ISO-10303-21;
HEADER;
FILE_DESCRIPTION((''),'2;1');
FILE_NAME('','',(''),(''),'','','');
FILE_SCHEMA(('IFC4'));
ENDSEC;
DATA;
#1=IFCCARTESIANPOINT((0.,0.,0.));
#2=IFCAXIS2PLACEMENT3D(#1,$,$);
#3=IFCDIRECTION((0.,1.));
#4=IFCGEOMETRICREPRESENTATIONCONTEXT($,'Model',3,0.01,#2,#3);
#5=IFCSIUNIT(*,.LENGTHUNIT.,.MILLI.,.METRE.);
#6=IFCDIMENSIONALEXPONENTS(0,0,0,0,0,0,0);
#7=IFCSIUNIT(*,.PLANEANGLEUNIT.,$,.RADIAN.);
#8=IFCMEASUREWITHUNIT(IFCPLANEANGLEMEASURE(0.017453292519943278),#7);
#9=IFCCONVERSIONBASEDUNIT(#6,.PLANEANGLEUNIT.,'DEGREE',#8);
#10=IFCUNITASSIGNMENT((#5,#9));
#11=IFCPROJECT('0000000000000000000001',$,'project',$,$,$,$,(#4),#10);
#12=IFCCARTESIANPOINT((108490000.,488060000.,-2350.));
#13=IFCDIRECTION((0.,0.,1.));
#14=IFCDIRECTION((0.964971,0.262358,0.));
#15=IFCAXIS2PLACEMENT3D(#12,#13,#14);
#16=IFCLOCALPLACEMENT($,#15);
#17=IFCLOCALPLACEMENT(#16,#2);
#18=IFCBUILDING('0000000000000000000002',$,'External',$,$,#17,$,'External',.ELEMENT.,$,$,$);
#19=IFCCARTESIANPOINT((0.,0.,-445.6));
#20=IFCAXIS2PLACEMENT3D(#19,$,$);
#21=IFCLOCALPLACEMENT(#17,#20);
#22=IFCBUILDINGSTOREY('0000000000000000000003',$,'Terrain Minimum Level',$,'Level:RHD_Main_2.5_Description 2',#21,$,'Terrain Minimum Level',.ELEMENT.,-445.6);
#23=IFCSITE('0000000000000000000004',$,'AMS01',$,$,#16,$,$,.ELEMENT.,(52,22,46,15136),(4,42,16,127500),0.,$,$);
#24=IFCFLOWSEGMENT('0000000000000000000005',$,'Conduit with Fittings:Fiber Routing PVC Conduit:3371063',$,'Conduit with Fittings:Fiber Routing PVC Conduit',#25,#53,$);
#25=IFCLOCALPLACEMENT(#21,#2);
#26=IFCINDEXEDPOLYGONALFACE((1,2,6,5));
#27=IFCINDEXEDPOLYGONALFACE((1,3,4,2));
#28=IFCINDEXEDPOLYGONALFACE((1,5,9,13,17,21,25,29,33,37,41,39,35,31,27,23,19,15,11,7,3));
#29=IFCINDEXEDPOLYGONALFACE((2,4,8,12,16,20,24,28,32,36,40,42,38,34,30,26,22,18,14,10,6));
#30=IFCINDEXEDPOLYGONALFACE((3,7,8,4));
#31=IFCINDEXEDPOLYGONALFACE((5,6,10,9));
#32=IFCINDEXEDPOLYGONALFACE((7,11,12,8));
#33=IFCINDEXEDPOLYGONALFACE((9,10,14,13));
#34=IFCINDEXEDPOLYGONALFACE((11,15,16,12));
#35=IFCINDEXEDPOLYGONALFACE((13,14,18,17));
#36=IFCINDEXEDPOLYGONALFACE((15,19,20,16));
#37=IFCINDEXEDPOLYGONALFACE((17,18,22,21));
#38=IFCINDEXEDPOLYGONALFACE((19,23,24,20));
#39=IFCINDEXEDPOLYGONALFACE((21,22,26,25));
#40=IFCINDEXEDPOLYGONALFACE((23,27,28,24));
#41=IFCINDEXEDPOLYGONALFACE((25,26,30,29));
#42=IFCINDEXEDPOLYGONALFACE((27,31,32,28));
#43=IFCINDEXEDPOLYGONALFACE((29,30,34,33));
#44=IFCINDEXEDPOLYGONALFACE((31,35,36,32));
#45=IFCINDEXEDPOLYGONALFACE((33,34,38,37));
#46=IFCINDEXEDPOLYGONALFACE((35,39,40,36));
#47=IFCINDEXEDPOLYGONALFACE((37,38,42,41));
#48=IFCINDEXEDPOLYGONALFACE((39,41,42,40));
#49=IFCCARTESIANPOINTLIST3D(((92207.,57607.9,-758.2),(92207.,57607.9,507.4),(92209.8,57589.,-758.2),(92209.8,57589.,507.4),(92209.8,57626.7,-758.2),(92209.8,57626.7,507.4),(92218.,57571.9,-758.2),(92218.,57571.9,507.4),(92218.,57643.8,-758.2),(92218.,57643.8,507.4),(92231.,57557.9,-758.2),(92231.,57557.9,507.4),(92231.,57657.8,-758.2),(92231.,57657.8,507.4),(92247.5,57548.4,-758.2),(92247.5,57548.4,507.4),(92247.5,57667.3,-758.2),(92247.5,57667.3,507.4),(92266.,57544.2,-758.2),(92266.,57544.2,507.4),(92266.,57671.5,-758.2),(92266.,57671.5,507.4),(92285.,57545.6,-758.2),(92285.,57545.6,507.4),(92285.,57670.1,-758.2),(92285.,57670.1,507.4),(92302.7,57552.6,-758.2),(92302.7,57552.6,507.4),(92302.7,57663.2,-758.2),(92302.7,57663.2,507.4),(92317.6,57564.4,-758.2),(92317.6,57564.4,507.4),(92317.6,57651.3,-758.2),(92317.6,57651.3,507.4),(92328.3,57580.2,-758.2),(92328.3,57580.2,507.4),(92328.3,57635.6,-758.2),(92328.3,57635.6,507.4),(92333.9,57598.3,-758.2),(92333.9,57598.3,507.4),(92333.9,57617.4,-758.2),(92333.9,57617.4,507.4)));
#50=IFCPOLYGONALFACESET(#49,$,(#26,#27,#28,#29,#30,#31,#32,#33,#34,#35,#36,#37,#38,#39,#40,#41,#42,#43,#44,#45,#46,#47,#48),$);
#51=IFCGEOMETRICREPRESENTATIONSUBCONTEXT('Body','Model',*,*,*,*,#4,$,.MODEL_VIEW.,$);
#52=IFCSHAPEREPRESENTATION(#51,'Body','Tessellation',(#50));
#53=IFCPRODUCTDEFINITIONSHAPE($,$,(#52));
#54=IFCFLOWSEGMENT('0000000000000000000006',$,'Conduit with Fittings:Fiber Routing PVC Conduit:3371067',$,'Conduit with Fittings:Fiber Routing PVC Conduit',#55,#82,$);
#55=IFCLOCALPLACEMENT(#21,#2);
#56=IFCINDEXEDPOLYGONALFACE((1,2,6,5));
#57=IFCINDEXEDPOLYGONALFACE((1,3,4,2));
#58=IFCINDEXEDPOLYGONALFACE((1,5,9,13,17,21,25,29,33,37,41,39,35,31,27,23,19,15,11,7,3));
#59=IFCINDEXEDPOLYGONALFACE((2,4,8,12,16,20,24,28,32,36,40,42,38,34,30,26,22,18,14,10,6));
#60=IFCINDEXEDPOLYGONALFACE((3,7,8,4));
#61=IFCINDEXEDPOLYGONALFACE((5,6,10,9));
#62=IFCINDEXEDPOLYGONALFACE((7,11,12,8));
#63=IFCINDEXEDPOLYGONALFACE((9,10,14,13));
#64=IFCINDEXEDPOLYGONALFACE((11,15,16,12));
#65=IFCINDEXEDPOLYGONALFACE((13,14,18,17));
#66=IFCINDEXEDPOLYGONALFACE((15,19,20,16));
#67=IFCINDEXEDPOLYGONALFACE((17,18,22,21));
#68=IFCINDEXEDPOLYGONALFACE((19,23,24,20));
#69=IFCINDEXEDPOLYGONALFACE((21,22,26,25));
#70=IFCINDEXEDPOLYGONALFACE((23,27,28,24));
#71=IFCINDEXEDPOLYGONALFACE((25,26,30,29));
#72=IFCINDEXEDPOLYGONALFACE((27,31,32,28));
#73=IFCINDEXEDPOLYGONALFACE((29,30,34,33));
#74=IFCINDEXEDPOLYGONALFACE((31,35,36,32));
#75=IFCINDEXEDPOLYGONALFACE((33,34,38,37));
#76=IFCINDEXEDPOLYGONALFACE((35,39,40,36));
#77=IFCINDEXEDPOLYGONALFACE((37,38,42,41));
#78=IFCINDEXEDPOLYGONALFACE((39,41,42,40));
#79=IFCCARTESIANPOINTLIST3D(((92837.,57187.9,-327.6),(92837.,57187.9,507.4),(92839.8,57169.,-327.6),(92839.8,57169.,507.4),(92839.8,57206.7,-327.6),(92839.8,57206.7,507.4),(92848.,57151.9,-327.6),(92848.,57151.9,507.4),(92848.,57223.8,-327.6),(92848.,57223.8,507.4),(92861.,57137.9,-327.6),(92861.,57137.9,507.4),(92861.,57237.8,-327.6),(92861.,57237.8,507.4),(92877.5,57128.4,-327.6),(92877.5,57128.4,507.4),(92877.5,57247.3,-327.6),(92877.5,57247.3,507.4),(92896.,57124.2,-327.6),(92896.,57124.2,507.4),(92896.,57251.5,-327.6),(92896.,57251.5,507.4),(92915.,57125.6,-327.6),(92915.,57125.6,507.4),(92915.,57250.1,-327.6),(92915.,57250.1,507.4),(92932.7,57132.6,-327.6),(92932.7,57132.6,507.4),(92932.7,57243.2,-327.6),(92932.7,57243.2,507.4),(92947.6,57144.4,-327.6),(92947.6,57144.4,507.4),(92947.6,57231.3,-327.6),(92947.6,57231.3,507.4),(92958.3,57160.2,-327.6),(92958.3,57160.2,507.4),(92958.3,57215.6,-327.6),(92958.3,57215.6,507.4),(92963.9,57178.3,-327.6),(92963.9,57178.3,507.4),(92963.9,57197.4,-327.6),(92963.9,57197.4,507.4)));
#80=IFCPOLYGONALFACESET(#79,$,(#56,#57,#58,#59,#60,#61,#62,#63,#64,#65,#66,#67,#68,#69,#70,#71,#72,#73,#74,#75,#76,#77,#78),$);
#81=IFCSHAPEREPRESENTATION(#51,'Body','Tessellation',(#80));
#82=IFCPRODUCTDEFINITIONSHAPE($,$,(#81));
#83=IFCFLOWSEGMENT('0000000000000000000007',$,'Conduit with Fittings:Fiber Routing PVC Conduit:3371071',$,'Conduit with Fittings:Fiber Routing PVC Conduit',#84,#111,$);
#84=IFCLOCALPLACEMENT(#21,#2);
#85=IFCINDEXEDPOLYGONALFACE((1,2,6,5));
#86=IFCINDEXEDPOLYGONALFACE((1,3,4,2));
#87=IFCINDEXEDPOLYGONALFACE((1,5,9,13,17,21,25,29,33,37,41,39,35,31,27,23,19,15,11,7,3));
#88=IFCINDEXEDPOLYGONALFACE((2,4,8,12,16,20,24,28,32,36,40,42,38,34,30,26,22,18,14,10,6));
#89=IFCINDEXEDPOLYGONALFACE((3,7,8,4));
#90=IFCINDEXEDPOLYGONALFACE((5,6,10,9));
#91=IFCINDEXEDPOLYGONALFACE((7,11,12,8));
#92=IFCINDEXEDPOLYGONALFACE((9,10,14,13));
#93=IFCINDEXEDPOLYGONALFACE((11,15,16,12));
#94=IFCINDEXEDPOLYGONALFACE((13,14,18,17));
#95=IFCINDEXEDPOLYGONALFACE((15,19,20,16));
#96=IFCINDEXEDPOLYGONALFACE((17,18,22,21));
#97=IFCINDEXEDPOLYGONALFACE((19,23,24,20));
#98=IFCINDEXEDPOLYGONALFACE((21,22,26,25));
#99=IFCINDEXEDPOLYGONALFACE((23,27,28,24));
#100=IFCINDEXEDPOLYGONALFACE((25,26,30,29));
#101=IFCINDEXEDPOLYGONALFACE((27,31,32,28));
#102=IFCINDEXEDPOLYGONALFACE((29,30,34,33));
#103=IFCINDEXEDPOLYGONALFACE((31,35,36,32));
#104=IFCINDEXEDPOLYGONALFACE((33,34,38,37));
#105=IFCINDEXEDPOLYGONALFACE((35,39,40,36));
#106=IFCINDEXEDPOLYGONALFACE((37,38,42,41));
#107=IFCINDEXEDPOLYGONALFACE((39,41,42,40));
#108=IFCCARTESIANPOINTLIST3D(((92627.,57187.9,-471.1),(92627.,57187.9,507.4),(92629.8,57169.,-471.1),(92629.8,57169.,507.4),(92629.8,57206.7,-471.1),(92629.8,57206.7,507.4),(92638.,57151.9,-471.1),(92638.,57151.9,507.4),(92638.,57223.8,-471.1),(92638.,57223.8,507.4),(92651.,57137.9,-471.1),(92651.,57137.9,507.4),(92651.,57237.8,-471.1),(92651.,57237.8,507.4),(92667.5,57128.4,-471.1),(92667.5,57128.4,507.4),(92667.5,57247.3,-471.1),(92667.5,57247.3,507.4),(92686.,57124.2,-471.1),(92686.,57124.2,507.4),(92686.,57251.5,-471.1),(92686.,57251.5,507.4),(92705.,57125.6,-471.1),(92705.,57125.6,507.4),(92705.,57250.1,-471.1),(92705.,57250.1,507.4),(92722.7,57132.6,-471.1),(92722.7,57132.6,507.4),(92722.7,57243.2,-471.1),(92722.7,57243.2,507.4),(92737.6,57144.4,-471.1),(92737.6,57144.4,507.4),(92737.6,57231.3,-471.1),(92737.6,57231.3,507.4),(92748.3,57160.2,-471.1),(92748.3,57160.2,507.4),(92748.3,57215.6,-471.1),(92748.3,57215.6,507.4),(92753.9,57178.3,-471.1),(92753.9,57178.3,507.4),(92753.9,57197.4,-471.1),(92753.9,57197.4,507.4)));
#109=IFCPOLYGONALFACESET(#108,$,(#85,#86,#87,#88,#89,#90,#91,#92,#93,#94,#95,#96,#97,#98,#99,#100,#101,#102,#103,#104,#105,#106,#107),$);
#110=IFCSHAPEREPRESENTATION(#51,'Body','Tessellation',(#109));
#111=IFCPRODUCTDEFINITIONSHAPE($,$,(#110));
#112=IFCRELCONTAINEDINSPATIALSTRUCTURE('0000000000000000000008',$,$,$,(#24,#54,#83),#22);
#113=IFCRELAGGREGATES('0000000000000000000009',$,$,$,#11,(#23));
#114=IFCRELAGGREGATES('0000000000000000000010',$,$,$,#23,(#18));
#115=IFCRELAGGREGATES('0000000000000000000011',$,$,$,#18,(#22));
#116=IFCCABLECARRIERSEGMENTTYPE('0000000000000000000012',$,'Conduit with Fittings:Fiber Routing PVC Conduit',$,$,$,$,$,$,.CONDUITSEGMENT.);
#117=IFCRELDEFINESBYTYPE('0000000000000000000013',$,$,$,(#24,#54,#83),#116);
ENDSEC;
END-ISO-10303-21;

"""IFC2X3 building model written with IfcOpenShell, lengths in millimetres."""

from ifc_helpers import new_model, entity, si_unit, converted_unit, direction, frame, frame_2d, origin, origin_2d_with_axis, place, context, subcontext, project, spatial, circle, extrude, type_object, element, save


model = new_model("IFC2X3")

# Units and contexts
model_context = context("Model", 3, precision=0.01, world=origin(), true_north=direction((0.0, 1.0)))
body_context = subcontext(model_context, "Body", "Model", "MODEL_VIEW")
ifc_project = project(units=[si_unit("LENGTHUNIT", "METRE", prefix="MILLI"), converted_unit("PLANEANGLEUNIT", "DEGREE", entity("IfcPlaneAngleMeasure", 0.017453292519943278), si_unit("PLANEANGLEUNIT", "RADIAN"), dimensions=[0, 0, 0, 0, 0, 0, 0])], contexts=[model_context])

# Site, building, storey
site_placement = place(None, frame((108490000.0, 488060000.0, -2350.0), z_axis=(0.0, 0.0, 1.0), x_axis=(0.964971, 0.262358, 0.0)))
site = spatial("IfcSite", under=ifc_project, at=site_placement, Name="AMS01", CompositionType="ELEMENT", RefLatitude=(52, 22, 46, 15136), RefLongitude=(4, 42, 16, 127500), RefElevation=0.0)
building_placement = place(site_placement, origin())
building = spatial("IfcBuilding", under=site, at=building_placement, Name="External", LongName="External", CompositionType="ELEMENT")
storey_placement = place(building_placement, frame((0.0, 0.0, -445.6)))
storey = spatial("IfcBuildingStorey", under=building, at=storey_placement, Name="Terrain Minimum Level", ObjectType="Level:RHD_Main_2.5_Description 2", LongName="Terrain Minimum Level", CompositionType="ELEMENT", Elevation=-445.6)

# Flow segments
cable_carrier_segment_type = type_object("IfcCableCarrierSegmentType", Name="Conduit with Fittings:Fiber Routing PVC Conduit", PredefinedType="CONDUITSEGMENT")
flow_segment_1_placement = place(storey_placement, origin())
element("IfcFlowSegment", 1, at=flow_segment_1_placement, inside=storey, type_object=cable_carrier_segment_type, Name="Conduit with Fittings:Fiber Routing PVC Conduit:3371063", ObjectType="Conduit with Fittings:Fiber Routing PVC Conduit", context=body_context, shape_type="SweptSolid", body=[
    extrude(circle(Radius=63.9, at=origin_2d_with_axis()), frame((92270.8, 57607.9, -758.2), z_axis=(0.0, 0.0, 1.0), x_axis=(-1.0, 0.0, 0.0)), (0.0, 0.0, 1.0), 1265.7),
])
flow_segment_2_placement = place(storey_placement, origin())
element("IfcFlowSegment", 2, at=flow_segment_2_placement, inside=storey, type_object=cable_carrier_segment_type, Name="Conduit with Fittings:Fiber Routing PVC Conduit:3371067", ObjectType="Conduit with Fittings:Fiber Routing PVC Conduit", context=body_context, shape_type="SweptSolid", body=[
    extrude(circle(Radius=63.9, at=frame_2d((0.0, 0.0), x_axis=(1.0, 0.0))), frame((92900.8, 57187.9, -327.6), z_axis=(0.0, 0.0, 1.0), x_axis=(-1.0, 0.0, 0.0)), (0.0, 0.0, 1.0), 835.0),
])
flow_segment_3_placement = place(storey_placement, origin())
element("IfcFlowSegment", 3, at=flow_segment_3_placement, inside=storey, type_object=cable_carrier_segment_type, Name="Conduit with Fittings:Fiber Routing PVC Conduit:3371071", ObjectType="Conduit with Fittings:Fiber Routing PVC Conduit", context=body_context, shape_type="SweptSolid", body=[
    extrude(circle(Radius=63.9, at=frame_2d((0.0, 0.0), x_axis=(1.0, 0.0))), frame((92690.8, 57187.9, -471.1), z_axis=(0.0, 0.0, 1.0), x_axis=(-1.0, 0.0, 0.0)), (0.0, 0.0, 1.0), 978.6),
])

save(model, "model.ifc")
